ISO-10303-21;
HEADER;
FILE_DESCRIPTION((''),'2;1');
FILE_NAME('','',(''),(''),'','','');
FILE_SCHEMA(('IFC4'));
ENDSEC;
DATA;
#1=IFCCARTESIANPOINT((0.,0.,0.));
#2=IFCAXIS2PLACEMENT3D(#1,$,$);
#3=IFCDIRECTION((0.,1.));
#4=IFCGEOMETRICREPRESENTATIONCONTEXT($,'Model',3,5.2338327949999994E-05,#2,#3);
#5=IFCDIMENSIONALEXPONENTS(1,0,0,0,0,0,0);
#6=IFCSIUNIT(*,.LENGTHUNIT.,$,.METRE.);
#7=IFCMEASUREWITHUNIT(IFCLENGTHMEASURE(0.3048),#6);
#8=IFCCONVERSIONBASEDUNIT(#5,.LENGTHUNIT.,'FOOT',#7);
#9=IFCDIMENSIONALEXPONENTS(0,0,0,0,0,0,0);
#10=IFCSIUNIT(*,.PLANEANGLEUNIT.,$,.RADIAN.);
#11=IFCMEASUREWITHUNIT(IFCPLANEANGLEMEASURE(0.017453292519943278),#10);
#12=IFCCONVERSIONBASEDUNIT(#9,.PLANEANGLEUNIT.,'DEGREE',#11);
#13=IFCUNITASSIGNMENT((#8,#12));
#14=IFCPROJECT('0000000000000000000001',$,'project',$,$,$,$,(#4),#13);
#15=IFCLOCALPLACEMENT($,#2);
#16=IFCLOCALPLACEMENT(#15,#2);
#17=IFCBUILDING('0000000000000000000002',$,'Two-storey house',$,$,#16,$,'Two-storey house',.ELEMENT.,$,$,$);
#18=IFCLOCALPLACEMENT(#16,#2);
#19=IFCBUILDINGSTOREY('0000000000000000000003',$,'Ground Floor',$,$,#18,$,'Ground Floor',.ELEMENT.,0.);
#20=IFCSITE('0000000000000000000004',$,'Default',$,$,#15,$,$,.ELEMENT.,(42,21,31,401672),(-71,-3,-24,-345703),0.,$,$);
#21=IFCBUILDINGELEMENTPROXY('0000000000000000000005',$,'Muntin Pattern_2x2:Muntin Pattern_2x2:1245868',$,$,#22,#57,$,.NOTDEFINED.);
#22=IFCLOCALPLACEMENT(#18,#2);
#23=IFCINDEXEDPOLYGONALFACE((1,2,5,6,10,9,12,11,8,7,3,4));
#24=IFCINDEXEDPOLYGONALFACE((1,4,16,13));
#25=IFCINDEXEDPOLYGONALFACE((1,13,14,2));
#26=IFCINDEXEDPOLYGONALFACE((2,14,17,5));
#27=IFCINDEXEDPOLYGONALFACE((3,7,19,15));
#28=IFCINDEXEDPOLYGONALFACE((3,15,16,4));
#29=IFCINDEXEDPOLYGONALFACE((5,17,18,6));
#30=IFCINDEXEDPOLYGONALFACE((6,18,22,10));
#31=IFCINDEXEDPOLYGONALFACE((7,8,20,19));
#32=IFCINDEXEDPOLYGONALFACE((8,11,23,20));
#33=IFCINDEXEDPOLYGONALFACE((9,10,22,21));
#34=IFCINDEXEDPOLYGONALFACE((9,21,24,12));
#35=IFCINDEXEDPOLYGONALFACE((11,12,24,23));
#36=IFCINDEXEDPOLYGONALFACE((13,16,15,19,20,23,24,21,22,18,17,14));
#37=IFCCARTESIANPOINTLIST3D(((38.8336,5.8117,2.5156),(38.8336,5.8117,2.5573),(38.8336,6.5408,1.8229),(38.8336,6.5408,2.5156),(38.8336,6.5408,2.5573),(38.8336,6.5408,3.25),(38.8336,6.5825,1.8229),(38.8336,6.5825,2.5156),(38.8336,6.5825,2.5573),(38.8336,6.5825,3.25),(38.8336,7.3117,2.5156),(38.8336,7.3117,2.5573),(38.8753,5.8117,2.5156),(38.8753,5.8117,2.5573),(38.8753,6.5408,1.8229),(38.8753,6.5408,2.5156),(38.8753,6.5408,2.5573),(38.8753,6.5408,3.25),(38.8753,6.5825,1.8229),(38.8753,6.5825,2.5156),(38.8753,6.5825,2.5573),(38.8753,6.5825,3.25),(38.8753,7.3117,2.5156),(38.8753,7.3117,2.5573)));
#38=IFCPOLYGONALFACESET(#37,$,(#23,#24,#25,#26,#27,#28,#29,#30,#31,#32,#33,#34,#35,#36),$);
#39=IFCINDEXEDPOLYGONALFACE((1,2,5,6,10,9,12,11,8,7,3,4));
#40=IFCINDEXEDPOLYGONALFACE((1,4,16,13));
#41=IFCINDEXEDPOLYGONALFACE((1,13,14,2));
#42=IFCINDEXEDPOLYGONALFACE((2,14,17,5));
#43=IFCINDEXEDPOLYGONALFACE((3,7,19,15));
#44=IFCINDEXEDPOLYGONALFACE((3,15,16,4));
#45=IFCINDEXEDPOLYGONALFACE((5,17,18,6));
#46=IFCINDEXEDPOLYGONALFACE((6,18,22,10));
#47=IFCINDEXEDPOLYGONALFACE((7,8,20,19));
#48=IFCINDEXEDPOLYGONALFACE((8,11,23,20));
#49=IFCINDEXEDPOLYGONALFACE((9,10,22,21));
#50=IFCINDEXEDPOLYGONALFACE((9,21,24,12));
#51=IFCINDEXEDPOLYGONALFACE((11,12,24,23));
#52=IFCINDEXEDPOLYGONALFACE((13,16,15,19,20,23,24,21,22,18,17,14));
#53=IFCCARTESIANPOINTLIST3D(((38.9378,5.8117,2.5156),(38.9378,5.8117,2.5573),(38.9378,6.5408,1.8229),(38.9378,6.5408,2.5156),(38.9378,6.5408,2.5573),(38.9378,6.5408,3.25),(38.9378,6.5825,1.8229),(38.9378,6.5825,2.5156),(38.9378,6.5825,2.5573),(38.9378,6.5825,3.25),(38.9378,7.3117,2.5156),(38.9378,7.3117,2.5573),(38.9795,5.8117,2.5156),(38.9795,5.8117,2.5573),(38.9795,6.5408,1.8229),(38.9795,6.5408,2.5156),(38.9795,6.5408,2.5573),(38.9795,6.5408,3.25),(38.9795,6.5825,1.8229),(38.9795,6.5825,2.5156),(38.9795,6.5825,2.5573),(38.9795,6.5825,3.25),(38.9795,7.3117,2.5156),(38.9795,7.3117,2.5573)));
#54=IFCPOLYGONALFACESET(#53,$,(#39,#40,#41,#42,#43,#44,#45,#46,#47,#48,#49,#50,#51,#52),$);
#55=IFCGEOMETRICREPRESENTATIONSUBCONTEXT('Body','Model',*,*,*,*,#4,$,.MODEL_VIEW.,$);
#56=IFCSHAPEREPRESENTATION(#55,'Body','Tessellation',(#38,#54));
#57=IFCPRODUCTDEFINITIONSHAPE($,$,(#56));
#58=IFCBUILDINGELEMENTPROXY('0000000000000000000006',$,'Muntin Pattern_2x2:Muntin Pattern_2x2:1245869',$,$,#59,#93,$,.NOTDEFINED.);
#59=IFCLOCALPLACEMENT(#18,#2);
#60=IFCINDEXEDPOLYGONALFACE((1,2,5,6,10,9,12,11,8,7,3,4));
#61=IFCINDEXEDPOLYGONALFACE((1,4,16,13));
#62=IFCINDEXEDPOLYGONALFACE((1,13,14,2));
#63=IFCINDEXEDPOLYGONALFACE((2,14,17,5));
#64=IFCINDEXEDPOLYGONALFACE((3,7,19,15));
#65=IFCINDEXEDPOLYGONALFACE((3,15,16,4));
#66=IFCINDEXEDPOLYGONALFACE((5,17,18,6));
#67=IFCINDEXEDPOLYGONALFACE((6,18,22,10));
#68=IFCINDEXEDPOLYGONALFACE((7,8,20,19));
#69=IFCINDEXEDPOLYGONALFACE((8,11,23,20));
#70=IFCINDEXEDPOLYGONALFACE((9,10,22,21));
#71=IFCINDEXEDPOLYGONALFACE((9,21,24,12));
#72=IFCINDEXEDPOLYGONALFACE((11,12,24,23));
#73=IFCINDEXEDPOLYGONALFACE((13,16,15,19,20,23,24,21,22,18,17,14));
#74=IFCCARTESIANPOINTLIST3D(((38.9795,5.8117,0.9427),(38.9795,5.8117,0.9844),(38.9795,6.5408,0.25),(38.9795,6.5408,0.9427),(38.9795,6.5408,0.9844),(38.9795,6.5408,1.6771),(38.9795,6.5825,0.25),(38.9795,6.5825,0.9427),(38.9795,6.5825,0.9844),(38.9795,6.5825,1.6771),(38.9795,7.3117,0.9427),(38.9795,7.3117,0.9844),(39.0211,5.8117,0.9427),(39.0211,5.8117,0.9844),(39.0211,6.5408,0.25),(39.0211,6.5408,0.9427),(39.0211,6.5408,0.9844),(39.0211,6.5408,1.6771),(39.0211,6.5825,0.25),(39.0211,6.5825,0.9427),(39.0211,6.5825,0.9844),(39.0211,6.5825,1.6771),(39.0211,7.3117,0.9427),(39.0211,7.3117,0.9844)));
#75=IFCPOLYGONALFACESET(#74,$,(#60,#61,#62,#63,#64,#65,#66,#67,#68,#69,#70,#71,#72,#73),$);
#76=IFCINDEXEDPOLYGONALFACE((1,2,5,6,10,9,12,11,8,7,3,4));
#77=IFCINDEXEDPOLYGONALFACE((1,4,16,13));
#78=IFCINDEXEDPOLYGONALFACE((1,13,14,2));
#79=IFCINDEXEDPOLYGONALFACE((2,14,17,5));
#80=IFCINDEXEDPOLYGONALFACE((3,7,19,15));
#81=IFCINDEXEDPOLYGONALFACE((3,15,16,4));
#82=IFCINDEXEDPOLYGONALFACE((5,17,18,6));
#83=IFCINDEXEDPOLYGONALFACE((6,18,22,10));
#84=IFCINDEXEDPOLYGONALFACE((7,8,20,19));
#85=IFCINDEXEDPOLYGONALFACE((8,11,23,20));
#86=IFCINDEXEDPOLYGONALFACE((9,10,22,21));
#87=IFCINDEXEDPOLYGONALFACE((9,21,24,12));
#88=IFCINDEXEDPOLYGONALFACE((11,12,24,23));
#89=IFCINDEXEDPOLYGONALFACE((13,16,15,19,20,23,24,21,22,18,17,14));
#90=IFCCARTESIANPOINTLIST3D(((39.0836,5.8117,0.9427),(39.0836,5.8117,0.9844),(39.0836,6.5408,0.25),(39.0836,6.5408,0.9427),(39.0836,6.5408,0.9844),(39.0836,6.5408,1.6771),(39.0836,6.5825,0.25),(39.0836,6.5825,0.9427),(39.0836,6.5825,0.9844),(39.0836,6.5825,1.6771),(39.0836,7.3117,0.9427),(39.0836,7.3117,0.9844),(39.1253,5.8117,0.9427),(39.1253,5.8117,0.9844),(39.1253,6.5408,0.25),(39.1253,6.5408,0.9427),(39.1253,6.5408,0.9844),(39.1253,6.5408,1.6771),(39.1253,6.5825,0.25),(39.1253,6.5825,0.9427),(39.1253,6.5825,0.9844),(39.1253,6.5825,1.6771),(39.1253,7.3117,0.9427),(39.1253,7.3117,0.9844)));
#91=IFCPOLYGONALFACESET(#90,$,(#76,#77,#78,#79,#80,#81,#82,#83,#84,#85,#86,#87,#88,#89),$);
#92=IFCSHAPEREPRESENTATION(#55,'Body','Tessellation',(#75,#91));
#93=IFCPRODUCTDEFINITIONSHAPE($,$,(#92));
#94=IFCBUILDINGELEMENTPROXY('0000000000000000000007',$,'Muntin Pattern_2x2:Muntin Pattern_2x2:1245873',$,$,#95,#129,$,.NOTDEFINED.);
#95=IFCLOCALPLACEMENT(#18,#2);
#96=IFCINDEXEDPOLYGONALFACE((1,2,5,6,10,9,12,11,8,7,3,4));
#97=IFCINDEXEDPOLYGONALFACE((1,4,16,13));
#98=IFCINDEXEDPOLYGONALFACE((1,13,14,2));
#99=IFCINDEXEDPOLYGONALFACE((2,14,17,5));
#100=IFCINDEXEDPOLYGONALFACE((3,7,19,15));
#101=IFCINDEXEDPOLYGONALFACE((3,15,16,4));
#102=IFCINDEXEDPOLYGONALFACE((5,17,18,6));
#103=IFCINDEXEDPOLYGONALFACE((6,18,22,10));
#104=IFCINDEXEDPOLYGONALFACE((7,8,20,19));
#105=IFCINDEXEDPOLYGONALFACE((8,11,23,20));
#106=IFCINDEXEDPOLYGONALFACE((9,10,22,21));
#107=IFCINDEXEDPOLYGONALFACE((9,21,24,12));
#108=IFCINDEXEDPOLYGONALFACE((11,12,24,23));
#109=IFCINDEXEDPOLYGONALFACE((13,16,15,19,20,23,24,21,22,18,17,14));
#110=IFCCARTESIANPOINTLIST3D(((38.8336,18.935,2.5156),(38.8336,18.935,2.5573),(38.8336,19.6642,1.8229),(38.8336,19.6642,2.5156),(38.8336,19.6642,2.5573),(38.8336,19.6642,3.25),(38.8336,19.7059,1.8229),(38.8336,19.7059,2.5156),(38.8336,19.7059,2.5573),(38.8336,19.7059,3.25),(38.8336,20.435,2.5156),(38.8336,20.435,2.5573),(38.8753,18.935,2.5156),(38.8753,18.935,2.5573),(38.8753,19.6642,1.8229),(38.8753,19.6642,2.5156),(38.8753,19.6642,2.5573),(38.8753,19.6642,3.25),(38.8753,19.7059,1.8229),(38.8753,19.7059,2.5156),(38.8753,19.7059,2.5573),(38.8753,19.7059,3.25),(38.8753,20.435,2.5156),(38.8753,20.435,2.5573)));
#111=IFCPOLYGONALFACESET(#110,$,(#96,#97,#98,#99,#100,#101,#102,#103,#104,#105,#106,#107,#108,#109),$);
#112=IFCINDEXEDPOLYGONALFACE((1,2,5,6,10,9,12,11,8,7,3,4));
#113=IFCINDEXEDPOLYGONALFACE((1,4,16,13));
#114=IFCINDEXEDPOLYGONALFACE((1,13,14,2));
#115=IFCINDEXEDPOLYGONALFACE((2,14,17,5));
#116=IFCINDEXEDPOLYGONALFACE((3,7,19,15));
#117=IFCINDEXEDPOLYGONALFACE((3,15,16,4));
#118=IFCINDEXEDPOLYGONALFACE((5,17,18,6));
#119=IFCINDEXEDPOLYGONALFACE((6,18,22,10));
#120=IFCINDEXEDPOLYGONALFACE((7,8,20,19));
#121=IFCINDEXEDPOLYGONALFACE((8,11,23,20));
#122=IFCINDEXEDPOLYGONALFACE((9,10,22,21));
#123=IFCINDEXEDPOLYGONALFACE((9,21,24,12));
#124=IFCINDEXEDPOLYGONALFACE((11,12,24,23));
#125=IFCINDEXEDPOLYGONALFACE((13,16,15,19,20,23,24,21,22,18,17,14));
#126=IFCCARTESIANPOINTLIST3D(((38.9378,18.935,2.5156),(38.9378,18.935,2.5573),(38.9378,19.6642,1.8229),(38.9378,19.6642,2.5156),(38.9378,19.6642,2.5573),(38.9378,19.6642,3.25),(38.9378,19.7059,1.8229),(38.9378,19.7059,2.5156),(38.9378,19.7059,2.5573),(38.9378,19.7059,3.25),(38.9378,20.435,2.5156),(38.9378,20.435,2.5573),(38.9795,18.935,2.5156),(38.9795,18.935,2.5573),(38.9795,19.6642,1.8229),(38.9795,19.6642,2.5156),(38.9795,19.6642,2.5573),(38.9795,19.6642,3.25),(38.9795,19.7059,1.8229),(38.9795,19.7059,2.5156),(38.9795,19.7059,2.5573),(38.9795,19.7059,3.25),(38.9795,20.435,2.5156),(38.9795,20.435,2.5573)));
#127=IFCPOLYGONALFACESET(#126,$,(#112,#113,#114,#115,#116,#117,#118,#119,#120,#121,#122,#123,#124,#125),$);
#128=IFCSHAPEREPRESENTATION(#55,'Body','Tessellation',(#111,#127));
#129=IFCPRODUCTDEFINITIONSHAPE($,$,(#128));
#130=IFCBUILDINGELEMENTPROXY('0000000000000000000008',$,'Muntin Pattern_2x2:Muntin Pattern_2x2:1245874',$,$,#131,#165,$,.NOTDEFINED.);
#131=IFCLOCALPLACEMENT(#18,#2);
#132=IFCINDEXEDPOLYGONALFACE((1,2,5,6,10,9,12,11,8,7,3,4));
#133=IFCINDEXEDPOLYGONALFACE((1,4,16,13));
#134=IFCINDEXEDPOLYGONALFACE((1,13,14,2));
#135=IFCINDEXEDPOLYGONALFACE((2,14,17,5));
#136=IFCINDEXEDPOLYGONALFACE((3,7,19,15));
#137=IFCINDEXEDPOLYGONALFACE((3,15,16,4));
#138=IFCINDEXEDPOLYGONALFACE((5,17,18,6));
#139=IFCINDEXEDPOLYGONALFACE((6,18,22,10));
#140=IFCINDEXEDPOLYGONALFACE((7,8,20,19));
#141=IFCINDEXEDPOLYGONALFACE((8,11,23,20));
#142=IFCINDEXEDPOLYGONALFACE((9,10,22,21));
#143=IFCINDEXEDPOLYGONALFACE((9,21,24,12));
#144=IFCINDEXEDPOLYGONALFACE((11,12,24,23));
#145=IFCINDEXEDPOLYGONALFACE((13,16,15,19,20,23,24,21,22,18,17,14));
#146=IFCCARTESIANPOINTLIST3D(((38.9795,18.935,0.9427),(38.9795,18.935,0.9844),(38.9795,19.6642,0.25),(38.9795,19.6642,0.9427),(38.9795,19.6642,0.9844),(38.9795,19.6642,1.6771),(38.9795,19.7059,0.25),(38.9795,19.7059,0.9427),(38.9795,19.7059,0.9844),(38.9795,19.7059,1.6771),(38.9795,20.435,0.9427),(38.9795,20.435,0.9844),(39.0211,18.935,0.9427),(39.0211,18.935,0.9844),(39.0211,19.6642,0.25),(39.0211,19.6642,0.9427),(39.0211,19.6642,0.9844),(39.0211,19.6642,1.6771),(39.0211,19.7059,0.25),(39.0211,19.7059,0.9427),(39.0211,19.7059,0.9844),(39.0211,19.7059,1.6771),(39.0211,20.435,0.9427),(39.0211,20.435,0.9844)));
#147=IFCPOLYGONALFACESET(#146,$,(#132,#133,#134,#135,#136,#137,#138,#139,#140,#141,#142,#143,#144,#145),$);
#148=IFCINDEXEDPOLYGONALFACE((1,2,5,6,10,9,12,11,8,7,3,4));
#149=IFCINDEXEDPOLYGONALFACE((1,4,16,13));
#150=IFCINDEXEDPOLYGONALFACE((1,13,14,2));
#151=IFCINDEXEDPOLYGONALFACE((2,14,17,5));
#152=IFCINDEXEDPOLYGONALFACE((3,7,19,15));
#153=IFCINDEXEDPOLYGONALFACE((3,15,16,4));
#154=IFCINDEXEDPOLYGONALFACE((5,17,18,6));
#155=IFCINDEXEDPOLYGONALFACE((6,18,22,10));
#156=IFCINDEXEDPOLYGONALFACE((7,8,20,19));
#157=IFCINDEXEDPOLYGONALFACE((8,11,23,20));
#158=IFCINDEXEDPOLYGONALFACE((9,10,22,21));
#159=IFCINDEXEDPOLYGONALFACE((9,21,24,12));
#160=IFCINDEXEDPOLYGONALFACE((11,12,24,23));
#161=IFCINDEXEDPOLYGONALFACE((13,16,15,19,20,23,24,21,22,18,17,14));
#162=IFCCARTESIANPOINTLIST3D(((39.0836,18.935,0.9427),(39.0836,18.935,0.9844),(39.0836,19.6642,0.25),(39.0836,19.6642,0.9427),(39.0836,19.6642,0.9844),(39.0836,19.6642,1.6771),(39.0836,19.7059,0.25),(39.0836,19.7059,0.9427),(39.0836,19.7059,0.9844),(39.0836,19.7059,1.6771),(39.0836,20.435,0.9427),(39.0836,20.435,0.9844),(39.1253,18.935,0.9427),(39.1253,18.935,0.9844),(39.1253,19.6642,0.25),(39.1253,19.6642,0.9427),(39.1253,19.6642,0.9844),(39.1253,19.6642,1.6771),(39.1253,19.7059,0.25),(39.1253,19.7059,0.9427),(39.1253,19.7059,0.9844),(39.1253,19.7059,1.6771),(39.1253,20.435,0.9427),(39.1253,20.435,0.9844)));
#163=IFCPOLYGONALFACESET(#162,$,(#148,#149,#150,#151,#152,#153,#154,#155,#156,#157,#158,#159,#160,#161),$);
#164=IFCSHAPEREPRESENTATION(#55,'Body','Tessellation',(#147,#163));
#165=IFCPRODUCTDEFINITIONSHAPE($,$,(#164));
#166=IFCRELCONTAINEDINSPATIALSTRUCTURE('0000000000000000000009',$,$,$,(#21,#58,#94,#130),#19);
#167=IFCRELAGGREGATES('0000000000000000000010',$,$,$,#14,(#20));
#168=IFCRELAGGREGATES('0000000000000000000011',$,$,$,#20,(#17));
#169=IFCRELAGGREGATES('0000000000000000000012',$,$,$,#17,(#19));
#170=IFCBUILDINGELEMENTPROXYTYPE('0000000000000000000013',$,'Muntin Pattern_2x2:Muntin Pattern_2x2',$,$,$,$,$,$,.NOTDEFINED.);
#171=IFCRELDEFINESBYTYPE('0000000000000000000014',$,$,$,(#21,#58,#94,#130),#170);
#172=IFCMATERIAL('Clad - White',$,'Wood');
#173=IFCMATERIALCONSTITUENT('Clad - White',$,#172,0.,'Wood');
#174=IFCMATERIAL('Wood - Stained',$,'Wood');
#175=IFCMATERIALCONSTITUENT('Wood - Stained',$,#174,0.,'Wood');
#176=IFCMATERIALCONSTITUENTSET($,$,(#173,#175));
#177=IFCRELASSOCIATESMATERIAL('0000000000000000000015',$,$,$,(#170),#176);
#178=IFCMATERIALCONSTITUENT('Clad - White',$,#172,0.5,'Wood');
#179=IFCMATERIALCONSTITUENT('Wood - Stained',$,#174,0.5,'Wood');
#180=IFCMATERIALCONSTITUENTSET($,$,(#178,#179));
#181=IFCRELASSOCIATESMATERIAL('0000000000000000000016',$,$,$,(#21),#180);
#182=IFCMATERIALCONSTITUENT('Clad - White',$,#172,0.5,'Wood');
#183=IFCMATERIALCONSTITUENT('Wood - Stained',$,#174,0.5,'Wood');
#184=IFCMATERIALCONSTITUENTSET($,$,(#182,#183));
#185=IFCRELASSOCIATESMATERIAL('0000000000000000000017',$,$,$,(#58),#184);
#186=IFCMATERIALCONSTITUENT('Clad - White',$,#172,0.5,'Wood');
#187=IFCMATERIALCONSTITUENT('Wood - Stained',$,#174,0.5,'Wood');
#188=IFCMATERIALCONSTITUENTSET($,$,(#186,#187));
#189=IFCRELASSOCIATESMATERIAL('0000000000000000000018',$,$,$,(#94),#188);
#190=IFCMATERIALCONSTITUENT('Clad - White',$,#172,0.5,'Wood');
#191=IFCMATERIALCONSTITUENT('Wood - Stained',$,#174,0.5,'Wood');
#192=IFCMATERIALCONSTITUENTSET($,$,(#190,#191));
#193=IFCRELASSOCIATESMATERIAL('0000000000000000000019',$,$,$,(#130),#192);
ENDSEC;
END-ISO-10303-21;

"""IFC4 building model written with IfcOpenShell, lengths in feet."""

from ifc_helpers import new_model, entity, si_unit, converted_unit, direction, frame, origin, place, context, subcontext, project, spatial, indexed_curve, outline, extrude, source, transform, mapped, material, constituent, constituent_set, type_object, type_shapes, element, save


model = new_model("IFC4")

# Units and contexts
model_context = context("Model", 3, precision=5.2338327949999994e-05, world=origin(), true_north=direction((0.0, 1.0)))
body_context = subcontext(model_context, "Body", "Model", "MODEL_VIEW")
ifc_project = project(units=[converted_unit("LENGTHUNIT", "FOOT", entity("IfcLengthMeasure", 0.3048), si_unit("LENGTHUNIT", "METRE"), dimensions=[1, 0, 0, 0, 0, 0, 0]), converted_unit("PLANEANGLEUNIT", "DEGREE", entity("IfcPlaneAngleMeasure", 0.017453292519943278), si_unit("PLANEANGLEUNIT", "RADIAN"), dimensions=[0, 0, 0, 0, 0, 0, 0])], contexts=[model_context])

# Site, building, storey
site_placement = place(None, origin())
site = spatial("IfcSite", under=ifc_project, at=site_placement, Name="Default", CompositionType="ELEMENT", RefLatitude=(42, 21, 31, 401672), RefLongitude=(-71, -3, -24, -345703), RefElevation=0.0)
building_placement = place(site_placement, origin())
building = spatial("IfcBuilding", under=site, at=building_placement, Name="Two-storey house", LongName="Two-storey house", CompositionType="ELEMENT")
storey_placement = place(building_placement, origin())
storey = spatial("IfcBuildingStorey", under=building, at=storey_placement, Name="Ground Floor", LongName="Ground Floor", CompositionType="ELEMENT", Elevation=0.0)

# Shared definitions
ifc_material_1 = material(Name="Wood - Stained", Category="Wood")

# Building element proxies
ifc_material_2 = material(Name="Clad - White", Category="Wood")
ifc_constituent_1 = constituent(ifc_material_2, Name="Clad - White", Category="Wood", fraction=0.5)
ifc_constituent_2 = constituent(ifc_material_1, Name="Wood - Stained", Category="Wood", fraction=0.5)
ifc_constituent_set_1 = constituent_set(constituents=[ifc_constituent_1, ifc_constituent_2])
ifc_constituent_3 = constituent(ifc_material_2, Name="Clad - White", Category="Wood", fraction=0.0)
ifc_constituent_4 = constituent(ifc_material_1, Name="Wood - Stained", Category="Wood", fraction=0.0)
ifc_constituent_set_2 = constituent_set(constituents=[ifc_constituent_3, ifc_constituent_4])
building_element_proxy_type_1 = type_object("IfcBuildingElementProxyType", Name="Muntin Pattern_2x2:Muntin Pattern_2x2", PredefinedType="NOTDEFINED", material=ifc_constituent_set_2)
shared_shape_1 = source(origin(), body_context, "Body", "SweptSolid", [
    extrude(outline(indexed_curve([(0.0208, -0.0208), (0.7135, -0.0208), (0.7135, 0.0208), (0.0208, 0.0208), (0.0208, 0.75), (-0.0208, 0.75), (-0.0208, 0.0208), (-0.7135, 0.0208), (-0.7135, -0.0208), (-0.0208, -0.0208), (-0.0208, -0.75), (0.0208, -0.75), (0.0208, -0.0208)], self_intersect=False)), frame((0.0, 0.0312, 0.7135), z_axis=(0.0, 1.0, 0.0), x_axis=(0.0, 0.0, 1.0)), (0.0, 0.0, 1.0), 0.0417),
    extrude(outline(indexed_curve([(0.0208, -0.0208), (0.7135, -0.0208), (0.7135, 0.0208), (0.0208, 0.0208), (0.0208, 0.75), (-0.0208, 0.75), (-0.0208, 0.0208), (-0.7135, 0.0208), (-0.7135, -0.0208), (-0.0208, -0.0208), (-0.0208, -0.75), (0.0208, -0.75), (0.0208, -0.0208)], self_intersect=False)), frame((0.0, -0.0729, 0.7135), z_axis=(0.0, 1.0, 0.0), x_axis=(0.0, 0.0, 1.0)), (0.0, 0.0, 1.0), 0.0417),
])
type_shapes(building_element_proxy_type_1, [shared_shape_1])
proxy_1_placement = place(storey_placement, frame((38.9065, 6.5617, 1.8229), z_axis=(0.0, 0.0, 1.0), x_axis=(0.0, 1.0, 0.0)))
element("IfcBuildingElementProxy", 1, at=proxy_1_placement, inside=storey, type_object=building_element_proxy_type_1, material=ifc_constituent_set_1, Name="Muntin Pattern_2x2:Muntin Pattern_2x2:1245868", PredefinedType="NOTDEFINED", context=body_context, shape_type="MappedRepresentation", body=[
    mapped(shared_shape_1, transform((0.0, 0.0, 0.0), scale=1.0)),
])
ifc_constituent_5 = constituent(ifc_material_2, Name="Clad - White", Category="Wood", fraction=0.5)
ifc_constituent_6 = constituent(ifc_material_1, Name="Wood - Stained", Category="Wood", fraction=0.5)
ifc_constituent_set_3 = constituent_set(constituents=[ifc_constituent_5, ifc_constituent_6])
proxy_2_placement = place(storey_placement, frame((39.0524, 6.5617, 0.25), z_axis=(0.0, 0.0, 1.0), x_axis=(0.0, 1.0, 0.0)))
element("IfcBuildingElementProxy", 2, at=proxy_2_placement, inside=storey, type_object=building_element_proxy_type_1, material=ifc_constituent_set_3, Name="Muntin Pattern_2x2:Muntin Pattern_2x2:1245869", PredefinedType="NOTDEFINED", context=body_context, shape_type="MappedRepresentation", body=[
    mapped(shared_shape_1, transform((0.0, 0.0, 0.0), scale=1.0)),
])
ifc_constituent_7 = constituent(ifc_material_2, Name="Clad - White", Category="Wood", fraction=0.5)
ifc_constituent_8 = constituent(ifc_material_1, Name="Wood - Stained", Category="Wood", fraction=0.5)
ifc_constituent_set_4 = constituent_set(constituents=[ifc_constituent_7, ifc_constituent_8])
proxy_3_placement = place(storey_placement, frame((38.9065, 19.685, 1.8229), z_axis=(0.0, 0.0, 1.0), x_axis=(0.0, 1.0, 0.0)))
element("IfcBuildingElementProxy", 3, at=proxy_3_placement, inside=storey, type_object=building_element_proxy_type_1, material=ifc_constituent_set_4, Name="Muntin Pattern_2x2:Muntin Pattern_2x2:1245873", PredefinedType="NOTDEFINED", context=body_context, shape_type="MappedRepresentation", body=[
    mapped(shared_shape_1, transform((0.0, 0.0, 0.0), scale=1.0)),
])
ifc_constituent_9 = constituent(ifc_material_2, Name="Clad - White", Category="Wood", fraction=0.5)
ifc_constituent_10 = constituent(ifc_material_1, Name="Wood - Stained", Category="Wood", fraction=0.5)
ifc_constituent_set_5 = constituent_set(constituents=[ifc_constituent_9, ifc_constituent_10])
proxy_4_placement = place(storey_placement, frame((39.0524, 19.685, 0.25), z_axis=(0.0, 0.0, 1.0), x_axis=(0.0, 1.0, 0.0)))
element("IfcBuildingElementProxy", 4, at=proxy_4_placement, inside=storey, type_object=building_element_proxy_type_1, material=ifc_constituent_set_5, Name="Muntin Pattern_2x2:Muntin Pattern_2x2:1245874", PredefinedType="NOTDEFINED", context=body_context, shape_type="MappedRepresentation", body=[
    mapped(shared_shape_1, transform((0.0, 0.0, 0.0), scale=1.0)),
])

save(model, "model.ifc")
